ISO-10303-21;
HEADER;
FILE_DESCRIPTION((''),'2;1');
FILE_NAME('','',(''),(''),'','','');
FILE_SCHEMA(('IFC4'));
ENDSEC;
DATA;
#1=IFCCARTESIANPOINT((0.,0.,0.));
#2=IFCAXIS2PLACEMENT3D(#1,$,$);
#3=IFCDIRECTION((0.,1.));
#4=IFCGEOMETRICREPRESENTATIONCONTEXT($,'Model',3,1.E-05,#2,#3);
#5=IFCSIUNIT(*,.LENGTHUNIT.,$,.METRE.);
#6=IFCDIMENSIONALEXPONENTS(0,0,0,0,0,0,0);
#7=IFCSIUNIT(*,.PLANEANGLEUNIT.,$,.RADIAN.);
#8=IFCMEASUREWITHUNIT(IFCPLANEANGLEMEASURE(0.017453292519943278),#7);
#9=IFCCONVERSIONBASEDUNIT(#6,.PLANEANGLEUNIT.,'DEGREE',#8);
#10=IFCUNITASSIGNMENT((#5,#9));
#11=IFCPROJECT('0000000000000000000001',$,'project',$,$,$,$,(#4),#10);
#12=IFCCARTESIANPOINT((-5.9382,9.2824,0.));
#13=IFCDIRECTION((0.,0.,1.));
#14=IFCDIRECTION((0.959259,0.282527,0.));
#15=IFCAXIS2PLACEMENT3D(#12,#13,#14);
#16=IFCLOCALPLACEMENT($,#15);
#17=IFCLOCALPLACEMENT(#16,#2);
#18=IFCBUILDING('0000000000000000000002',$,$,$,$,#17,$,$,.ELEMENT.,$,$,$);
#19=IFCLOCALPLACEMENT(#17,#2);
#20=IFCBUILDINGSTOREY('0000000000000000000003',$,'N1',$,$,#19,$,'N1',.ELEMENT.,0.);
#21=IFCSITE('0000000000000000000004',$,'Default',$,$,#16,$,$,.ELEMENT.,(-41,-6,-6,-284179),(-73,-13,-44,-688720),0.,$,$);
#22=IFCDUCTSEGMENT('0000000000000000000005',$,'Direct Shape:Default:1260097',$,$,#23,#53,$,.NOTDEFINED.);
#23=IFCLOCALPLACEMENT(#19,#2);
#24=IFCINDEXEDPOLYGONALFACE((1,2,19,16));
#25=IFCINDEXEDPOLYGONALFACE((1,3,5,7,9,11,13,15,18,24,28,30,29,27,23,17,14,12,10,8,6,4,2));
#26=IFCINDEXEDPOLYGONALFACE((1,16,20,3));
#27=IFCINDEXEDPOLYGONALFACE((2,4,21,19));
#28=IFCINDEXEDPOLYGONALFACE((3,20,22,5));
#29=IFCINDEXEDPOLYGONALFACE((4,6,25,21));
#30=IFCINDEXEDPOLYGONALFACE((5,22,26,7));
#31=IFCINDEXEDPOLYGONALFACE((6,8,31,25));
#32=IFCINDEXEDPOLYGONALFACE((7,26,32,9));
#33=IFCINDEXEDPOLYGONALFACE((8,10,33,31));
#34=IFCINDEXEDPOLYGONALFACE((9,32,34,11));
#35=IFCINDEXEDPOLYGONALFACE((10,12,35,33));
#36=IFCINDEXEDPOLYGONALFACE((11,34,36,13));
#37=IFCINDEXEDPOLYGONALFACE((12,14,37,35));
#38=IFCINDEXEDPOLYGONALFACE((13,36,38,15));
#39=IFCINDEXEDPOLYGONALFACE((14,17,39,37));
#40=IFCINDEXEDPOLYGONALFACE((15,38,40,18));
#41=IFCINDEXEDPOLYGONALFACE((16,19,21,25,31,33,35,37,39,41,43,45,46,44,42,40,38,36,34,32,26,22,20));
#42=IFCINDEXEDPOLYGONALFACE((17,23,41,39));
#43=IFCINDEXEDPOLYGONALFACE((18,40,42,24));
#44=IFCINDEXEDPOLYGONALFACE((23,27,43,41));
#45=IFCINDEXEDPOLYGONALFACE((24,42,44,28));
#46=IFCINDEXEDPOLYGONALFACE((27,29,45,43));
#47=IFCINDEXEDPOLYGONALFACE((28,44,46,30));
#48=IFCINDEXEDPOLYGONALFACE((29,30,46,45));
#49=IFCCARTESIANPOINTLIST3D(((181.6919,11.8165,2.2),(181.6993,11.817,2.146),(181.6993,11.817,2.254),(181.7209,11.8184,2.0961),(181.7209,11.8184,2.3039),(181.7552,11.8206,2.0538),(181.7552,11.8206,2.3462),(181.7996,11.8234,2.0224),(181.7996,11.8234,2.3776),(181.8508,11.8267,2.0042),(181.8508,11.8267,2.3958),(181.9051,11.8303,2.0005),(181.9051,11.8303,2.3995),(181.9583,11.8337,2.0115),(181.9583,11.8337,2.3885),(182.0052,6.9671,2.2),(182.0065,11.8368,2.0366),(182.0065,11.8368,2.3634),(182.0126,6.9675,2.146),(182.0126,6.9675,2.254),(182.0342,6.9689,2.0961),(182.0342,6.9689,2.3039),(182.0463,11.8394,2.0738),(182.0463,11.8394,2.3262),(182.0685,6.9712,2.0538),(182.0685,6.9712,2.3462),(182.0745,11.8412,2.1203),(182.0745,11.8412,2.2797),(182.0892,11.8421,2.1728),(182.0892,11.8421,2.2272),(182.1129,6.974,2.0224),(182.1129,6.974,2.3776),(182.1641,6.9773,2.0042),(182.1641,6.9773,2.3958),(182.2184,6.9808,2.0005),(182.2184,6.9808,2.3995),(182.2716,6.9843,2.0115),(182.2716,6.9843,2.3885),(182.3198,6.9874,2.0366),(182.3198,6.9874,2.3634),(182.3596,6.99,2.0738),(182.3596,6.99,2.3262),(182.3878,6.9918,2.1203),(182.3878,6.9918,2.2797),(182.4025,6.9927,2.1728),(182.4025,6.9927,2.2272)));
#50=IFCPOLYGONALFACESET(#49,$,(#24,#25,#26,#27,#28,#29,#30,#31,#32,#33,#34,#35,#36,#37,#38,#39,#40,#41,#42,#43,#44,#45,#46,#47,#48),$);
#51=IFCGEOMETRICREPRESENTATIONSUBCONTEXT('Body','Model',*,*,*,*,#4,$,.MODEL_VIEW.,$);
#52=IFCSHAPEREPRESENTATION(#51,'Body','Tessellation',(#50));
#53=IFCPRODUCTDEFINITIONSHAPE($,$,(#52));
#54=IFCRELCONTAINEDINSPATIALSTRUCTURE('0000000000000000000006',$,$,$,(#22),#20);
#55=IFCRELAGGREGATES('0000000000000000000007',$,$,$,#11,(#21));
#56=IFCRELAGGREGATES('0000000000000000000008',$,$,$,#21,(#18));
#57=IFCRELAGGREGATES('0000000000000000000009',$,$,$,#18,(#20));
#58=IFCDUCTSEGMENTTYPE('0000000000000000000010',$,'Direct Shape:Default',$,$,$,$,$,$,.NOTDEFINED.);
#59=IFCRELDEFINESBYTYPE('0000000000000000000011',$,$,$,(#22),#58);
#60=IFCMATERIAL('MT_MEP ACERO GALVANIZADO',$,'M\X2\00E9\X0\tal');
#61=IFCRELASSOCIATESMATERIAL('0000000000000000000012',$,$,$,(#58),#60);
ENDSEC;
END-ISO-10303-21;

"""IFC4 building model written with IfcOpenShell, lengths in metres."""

from ifc_helpers import new_model, entity, si_unit, converted_unit, direction, frame, origin, origin_2d_with_axis, place, context, subcontext, project, spatial, circle, extrude, material, type_object, element, save


model = new_model("IFC4")

# Units and contexts
model_context = context("Model", 3, precision=1e-05, world=origin(), true_north=direction((0.0, 1.0)))
body_context = subcontext(model_context, "Body", "Model", "MODEL_VIEW")
ifc_project = project(units=[si_unit("LENGTHUNIT", "METRE"), converted_unit("PLANEANGLEUNIT", "DEGREE", entity("IfcPlaneAngleMeasure", 0.017453292519943278), si_unit("PLANEANGLEUNIT", "RADIAN"), dimensions=[0, 0, 0, 0, 0, 0, 0])], contexts=[model_context])

# Site, building, storey
site_placement = place(None, frame((-5.9382, 9.2824, 0.0), z_axis=(0.0, 0.0, 1.0), x_axis=(0.959259, 0.282527, 0.0)))
site = spatial("IfcSite", under=ifc_project, at=site_placement, Name="Default", CompositionType="ELEMENT", RefLatitude=(-41, -6, -6, -284179), RefLongitude=(-73, -13, -44, -688720), RefElevation=0.0)
building_placement = place(site_placement, origin())
building = spatial("IfcBuilding", under=site, at=building_placement, CompositionType="ELEMENT")
storey_placement = place(building_placement, origin())
storey = spatial("IfcBuildingStorey", under=building, at=storey_placement, Name="N1", LongName="N1", CompositionType="ELEMENT", Elevation=0.0)

# Duct segment
ifc_material_1 = material(Name="MT_MEP ACERO GALVANIZADO", Category="Métal")
duct_segment_type = type_object("IfcDuctSegmentType", Name="Direct Shape:Default", PredefinedType="NOTDEFINED", material=ifc_material_1)
duct_segment_placement = place(storey_placement, origin())
element("IfcDuctSegment", 1, at=duct_segment_placement, inside=storey, type_object=duct_segment_type, Name="Direct Shape:Default:1260097", PredefinedType="NOTDEFINED", context=body_context, shape_type="SweptSolid", body=[
    extrude(circle(Radius=0.2, at=origin_2d_with_axis()), frame((182.2047, 6.98, 2.2), z_axis=(-0.064471, 0.99792, 0.0), x_axis=(-0.99792, -0.064471, 0.0)), (0.0, 0.0, 1.0), 4.8595),
])

save(model, "model.ifc")
